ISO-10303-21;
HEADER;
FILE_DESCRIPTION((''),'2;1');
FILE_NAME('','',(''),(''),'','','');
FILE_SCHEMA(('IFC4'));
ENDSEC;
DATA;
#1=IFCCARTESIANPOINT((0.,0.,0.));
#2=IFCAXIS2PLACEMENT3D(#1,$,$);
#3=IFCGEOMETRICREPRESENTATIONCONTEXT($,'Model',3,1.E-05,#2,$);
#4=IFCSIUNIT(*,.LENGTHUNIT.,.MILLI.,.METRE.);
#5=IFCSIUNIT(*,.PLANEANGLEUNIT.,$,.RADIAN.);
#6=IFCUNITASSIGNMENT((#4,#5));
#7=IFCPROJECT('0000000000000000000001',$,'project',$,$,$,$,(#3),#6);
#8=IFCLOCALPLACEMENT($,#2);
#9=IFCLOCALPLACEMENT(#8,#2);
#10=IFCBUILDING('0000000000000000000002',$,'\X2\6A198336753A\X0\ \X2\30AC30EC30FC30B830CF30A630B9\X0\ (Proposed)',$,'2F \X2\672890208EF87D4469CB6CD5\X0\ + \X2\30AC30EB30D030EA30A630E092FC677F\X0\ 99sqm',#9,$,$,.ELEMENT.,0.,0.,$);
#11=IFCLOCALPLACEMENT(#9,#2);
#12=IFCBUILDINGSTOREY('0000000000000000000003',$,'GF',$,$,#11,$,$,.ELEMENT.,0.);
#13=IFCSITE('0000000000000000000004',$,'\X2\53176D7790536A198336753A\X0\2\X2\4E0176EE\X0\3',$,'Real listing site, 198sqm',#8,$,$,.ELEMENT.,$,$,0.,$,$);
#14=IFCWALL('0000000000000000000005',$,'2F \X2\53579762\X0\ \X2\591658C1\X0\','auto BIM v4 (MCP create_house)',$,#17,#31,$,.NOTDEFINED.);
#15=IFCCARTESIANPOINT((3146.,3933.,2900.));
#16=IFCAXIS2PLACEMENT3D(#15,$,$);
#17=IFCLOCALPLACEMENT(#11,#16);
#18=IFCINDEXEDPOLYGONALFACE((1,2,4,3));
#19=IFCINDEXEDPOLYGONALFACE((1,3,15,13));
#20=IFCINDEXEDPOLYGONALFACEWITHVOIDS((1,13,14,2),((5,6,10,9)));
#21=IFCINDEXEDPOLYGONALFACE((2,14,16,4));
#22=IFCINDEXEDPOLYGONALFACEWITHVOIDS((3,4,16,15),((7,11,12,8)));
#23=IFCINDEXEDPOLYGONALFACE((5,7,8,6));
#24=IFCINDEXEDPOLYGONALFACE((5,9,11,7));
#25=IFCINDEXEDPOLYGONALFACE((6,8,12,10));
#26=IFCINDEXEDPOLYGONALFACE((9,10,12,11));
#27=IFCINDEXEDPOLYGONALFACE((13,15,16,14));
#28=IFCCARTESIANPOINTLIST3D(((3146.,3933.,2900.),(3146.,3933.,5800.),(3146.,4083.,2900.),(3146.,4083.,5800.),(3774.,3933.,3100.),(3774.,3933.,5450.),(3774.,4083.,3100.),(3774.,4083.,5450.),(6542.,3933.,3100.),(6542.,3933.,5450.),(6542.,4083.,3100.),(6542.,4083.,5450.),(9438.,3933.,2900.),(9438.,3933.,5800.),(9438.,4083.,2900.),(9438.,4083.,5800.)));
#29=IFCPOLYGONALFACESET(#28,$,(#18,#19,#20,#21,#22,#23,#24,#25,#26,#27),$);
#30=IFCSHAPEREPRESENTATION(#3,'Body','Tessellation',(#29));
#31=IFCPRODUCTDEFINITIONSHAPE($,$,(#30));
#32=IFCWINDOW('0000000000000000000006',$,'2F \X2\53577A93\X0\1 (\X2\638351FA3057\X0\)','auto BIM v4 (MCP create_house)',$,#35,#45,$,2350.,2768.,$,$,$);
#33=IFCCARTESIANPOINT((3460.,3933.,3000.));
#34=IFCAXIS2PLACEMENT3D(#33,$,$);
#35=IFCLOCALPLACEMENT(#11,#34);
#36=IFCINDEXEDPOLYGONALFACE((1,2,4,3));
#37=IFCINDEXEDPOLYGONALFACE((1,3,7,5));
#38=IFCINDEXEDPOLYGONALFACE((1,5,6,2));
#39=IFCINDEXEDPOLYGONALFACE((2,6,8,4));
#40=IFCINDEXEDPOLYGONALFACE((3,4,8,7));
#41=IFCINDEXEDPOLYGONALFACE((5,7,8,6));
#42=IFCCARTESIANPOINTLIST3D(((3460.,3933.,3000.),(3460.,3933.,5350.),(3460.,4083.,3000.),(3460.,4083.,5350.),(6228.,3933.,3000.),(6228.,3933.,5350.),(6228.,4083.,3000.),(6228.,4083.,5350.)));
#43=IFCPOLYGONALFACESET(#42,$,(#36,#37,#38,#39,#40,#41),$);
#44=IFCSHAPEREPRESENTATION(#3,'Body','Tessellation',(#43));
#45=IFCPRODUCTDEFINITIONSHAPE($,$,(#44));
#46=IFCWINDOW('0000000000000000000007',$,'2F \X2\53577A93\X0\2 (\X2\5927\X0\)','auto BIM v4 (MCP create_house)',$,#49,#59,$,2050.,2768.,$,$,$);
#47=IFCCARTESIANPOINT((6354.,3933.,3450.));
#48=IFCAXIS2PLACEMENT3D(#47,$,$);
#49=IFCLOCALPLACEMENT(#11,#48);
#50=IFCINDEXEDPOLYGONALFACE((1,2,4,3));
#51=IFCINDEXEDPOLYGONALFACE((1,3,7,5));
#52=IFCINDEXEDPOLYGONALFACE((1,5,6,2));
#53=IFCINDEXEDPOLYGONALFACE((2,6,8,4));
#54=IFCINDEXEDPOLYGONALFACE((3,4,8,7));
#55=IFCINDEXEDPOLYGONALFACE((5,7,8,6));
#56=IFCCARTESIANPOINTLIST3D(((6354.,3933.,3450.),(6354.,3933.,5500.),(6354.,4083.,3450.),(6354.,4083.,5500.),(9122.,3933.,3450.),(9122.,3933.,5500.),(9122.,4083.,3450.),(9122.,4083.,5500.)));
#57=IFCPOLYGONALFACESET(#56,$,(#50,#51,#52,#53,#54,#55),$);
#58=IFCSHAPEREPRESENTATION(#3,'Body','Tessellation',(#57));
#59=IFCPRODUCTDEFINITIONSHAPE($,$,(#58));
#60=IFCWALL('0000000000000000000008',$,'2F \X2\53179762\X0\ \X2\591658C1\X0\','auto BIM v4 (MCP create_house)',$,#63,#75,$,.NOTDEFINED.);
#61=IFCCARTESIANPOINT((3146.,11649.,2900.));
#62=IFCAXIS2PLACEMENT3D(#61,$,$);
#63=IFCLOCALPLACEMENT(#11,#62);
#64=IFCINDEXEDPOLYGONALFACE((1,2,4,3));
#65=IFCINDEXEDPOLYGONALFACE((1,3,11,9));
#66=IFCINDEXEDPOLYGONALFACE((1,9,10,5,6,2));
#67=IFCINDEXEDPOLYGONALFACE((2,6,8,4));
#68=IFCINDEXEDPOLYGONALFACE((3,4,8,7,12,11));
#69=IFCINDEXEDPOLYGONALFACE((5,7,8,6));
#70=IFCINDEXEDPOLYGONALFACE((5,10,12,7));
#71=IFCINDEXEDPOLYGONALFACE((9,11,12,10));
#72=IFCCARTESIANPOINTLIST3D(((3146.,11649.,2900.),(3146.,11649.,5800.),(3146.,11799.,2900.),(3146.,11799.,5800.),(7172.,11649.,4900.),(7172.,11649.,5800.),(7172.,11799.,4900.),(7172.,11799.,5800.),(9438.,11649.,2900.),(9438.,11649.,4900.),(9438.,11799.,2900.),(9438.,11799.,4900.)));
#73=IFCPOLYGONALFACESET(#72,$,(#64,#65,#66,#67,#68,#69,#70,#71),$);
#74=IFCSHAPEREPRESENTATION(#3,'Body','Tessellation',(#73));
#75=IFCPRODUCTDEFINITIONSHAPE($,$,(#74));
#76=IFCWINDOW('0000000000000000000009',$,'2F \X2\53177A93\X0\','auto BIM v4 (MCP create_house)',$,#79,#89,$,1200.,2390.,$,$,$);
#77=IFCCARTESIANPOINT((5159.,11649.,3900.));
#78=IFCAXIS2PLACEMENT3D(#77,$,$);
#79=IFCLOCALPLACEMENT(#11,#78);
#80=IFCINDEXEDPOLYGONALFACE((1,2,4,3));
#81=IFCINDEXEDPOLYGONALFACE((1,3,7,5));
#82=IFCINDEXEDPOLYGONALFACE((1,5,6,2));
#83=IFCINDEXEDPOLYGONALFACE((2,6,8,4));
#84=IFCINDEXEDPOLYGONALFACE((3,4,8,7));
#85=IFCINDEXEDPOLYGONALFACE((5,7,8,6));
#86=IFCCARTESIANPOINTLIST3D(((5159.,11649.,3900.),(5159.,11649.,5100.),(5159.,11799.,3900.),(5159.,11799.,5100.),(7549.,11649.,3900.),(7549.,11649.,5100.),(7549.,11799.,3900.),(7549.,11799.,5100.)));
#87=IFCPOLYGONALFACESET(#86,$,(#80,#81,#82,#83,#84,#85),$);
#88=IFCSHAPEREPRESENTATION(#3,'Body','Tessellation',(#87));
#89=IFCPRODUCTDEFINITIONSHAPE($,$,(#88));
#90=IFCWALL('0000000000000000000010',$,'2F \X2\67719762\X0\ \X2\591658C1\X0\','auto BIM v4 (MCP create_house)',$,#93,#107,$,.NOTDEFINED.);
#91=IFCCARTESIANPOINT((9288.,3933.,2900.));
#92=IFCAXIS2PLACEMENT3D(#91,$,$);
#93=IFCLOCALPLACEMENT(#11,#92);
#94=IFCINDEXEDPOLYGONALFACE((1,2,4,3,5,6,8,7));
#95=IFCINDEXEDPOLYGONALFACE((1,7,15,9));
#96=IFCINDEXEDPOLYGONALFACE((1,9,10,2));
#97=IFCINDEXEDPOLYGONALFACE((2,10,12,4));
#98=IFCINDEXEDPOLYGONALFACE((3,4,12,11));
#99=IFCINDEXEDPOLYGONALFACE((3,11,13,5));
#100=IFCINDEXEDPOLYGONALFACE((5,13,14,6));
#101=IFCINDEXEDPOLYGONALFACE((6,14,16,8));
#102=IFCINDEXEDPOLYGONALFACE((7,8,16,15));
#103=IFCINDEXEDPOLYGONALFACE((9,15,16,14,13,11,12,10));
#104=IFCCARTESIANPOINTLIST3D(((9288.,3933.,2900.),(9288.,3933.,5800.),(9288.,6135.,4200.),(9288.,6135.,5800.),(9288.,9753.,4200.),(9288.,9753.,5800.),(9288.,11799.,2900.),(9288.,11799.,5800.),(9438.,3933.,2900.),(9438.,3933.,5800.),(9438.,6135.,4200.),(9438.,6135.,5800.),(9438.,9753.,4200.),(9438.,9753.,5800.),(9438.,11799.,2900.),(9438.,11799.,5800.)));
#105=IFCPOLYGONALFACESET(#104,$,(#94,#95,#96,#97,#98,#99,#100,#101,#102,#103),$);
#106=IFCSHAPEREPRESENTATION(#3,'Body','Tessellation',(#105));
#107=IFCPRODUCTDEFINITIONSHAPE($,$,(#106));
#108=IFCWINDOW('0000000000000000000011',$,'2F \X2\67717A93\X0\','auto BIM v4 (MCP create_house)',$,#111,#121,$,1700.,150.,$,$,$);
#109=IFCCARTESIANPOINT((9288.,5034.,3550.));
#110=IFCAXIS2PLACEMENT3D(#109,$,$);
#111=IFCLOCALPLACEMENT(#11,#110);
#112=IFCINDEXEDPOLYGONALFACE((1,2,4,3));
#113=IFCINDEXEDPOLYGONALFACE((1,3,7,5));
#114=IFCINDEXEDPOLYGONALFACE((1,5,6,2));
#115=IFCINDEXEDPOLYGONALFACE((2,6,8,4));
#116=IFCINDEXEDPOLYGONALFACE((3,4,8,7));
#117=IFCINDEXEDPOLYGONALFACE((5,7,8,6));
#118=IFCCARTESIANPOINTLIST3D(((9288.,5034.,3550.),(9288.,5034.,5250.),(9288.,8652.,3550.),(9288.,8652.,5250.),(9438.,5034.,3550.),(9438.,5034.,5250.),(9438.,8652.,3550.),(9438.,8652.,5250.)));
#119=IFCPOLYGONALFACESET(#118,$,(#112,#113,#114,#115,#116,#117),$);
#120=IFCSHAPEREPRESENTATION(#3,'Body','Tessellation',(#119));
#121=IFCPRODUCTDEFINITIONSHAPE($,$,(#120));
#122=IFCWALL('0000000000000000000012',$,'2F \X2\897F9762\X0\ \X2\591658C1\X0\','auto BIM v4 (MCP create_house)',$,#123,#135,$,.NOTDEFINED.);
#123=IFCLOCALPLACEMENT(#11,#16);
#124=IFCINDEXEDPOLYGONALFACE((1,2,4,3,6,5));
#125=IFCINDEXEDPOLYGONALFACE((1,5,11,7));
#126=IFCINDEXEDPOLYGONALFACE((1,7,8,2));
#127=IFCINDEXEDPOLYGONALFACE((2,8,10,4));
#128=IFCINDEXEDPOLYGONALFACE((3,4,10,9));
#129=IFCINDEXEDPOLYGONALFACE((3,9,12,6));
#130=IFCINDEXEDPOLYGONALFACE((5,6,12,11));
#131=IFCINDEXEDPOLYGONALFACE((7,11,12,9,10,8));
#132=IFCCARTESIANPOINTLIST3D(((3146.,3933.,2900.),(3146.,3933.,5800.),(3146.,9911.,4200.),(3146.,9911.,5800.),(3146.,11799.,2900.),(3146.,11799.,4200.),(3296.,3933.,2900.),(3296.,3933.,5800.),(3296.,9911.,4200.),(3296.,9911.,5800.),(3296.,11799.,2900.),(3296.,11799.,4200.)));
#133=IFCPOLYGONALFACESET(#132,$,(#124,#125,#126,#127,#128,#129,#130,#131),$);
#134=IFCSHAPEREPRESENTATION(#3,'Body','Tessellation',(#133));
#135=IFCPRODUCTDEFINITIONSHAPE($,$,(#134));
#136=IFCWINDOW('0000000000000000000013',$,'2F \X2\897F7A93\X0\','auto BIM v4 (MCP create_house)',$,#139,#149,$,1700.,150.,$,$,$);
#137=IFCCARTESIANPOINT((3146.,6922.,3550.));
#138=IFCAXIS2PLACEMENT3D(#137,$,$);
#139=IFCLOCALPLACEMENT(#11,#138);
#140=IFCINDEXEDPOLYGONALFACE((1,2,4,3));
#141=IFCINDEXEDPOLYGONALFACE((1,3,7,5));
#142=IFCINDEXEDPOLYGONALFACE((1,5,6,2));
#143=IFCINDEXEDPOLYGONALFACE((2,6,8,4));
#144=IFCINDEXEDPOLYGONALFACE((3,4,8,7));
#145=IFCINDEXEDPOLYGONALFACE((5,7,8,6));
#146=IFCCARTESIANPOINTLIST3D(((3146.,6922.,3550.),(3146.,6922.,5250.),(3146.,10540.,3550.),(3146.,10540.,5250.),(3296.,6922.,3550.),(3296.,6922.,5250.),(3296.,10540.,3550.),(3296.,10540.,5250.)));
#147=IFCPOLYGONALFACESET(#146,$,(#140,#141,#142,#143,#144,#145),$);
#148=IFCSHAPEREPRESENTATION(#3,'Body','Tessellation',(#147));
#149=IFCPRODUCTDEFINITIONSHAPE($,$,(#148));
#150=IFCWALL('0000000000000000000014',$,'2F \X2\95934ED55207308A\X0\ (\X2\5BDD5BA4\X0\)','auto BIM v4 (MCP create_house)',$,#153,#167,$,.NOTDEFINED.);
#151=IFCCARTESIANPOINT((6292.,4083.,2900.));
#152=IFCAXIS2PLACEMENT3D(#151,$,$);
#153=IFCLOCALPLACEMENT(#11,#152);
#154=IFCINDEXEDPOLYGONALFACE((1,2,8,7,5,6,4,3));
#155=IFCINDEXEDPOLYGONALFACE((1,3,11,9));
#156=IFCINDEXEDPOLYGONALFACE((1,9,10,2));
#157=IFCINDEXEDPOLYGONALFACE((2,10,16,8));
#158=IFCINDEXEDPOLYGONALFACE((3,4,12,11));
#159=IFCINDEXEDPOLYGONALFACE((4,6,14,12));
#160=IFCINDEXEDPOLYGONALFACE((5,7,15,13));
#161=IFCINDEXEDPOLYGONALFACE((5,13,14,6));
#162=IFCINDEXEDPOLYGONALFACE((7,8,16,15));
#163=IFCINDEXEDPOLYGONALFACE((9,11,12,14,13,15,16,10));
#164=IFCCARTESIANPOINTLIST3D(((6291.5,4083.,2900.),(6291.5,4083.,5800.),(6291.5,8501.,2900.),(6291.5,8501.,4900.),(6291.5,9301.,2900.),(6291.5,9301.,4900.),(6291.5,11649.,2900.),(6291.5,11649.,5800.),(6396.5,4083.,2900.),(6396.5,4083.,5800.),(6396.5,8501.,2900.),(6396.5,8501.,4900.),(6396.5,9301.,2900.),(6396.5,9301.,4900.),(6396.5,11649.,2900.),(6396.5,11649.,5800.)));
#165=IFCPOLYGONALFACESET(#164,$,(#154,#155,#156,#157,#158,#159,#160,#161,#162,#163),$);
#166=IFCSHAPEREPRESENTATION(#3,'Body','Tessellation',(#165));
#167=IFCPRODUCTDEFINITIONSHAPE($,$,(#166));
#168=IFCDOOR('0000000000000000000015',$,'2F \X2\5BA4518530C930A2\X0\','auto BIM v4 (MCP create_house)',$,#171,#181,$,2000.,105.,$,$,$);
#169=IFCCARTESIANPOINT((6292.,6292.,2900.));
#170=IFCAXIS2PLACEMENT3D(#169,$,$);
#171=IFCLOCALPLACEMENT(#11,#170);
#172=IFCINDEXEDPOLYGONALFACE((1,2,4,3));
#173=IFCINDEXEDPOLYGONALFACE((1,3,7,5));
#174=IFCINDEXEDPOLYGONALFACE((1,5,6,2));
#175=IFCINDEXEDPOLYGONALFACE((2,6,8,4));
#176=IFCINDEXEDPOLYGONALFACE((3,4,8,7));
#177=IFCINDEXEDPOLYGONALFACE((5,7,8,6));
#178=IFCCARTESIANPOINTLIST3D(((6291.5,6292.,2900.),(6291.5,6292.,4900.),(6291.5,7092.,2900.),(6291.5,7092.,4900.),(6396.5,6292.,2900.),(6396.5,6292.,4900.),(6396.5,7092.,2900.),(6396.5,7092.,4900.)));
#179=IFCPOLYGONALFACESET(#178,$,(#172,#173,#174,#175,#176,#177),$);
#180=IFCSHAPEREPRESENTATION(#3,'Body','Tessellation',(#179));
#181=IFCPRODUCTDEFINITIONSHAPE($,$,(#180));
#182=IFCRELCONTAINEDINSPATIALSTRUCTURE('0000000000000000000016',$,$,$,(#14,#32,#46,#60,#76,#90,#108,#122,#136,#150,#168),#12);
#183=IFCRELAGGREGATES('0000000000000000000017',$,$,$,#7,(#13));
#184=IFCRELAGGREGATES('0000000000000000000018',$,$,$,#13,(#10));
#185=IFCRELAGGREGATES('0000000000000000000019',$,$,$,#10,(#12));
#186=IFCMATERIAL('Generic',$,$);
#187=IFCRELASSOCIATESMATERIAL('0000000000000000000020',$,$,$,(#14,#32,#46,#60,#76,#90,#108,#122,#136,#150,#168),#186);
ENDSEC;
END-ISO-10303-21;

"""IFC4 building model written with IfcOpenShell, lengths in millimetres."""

from ifc_helpers import new_model, si_unit, frame, frame_2d, origin, place, context, project, spatial, rectangle, extrude, material, element, fill, save


model = new_model("IFC4")

# Units and contexts
model_context = context("Model", 3, precision=1e-05, world=origin())
ifc_project = project(units=[si_unit("LENGTHUNIT", "METRE", prefix="MILLI"), si_unit("PLANEANGLEUNIT", "RADIAN")], contexts=[model_context])

# Site, building, storey
site_placement = place(None, origin())
site = spatial("IfcSite", under=ifc_project, at=site_placement, Name="北海道標茶町2丁目3", ObjectType="Real listing site, 198sqm", CompositionType="ELEMENT", RefElevation=0.0)
building_placement = place(site_placement, origin())
building = spatial("IfcBuilding", under=site, at=building_placement, Name="標茶町 ガレージハウス (Proposed)", ObjectType="2F 木造軸組構法 + ガルバリウム鋼板 99sqm", CompositionType="ELEMENT", ElevationOfRefHeight=0.0, ElevationOfTerrain=0.0)
storey_placement = place(building_placement, origin())
storey = spatial("IfcBuildingStorey", under=building, at=storey_placement, Name="GF", CompositionType="ELEMENT", Elevation=0.0)

# Shared definitions
ifc_material = material(Name="Generic")

# Wall, openings, windows
wall_1_placement = place(storey_placement, frame((3146.0, 3933.0, 2900.0)))
wall_1 = element("IfcWall", 1, at=wall_1_placement, inside=storey, material=ifc_material, Name="2F 南面 外壁", Description="auto BIM v4 (MCP create_house)", PredefinedType="NOTDEFINED", context=model_context, shape_type="SweptSolid", body=[
    extrude(rectangle(XDim=6292.0, YDim=150.0, at=frame_2d((3146.0, 75.0))), frame((3146.0, 3933.0, 2900.0)), (0.0, 0.0, 1.0), 2900.0),
])
opening_1_placement = place(storey_placement, frame((3460.0, 3933.0, 3000.0)))
opening_1 = element("IfcOpeningElement", 2, at=opening_1_placement, cuts=wall_1, PredefinedType="NOTDEFINED", context=model_context, shape_type="SweptSolid", body=[
    extrude(rectangle(XDim=2768.0, YDim=150.0, at=frame_2d((1384.0, 75.0))), frame((3460.0, 3933.0, 3000.0)), (0.0, 0.0, 1.0), 2350.0),
])
opening_2_placement = place(storey_placement, frame((6354.0, 3933.0, 3450.0)))
opening_2 = element("IfcOpeningElement", 3, at=opening_2_placement, cuts=wall_1, PredefinedType="NOTDEFINED", context=model_context, shape_type="SweptSolid", body=[
    extrude(rectangle(XDim=2768.0, YDim=150.0, at=frame_2d((1384.0, 75.0))), frame((6354.0, 3933.0, 3450.0)), (0.0, 0.0, 1.0), 2050.0),
])
window_1_placement = place(storey_placement, frame((3460.0, 3933.0, 3000.0)))
window_1 = element("IfcWindow", 4, at=window_1_placement, inside=storey, material=ifc_material, Name="2F 南窓1 (掃出し)", Description="auto BIM v4 (MCP create_house)", OverallHeight=2350.0, OverallWidth=2768.0, context=model_context, shape_type="SweptSolid", body=[
    extrude(rectangle(XDim=2768.0, YDim=150.0, at=frame_2d((1384.0, 75.0))), frame((3460.0, 3933.0, 3000.0)), (0.0, 0.0, 1.0), 2350.0),
])
fill(opening_1, window_1)
window_2_placement = place(storey_placement, frame((6354.0, 3933.0, 3450.0)))
window_2 = element("IfcWindow", 5, at=window_2_placement, inside=storey, material=ifc_material, Name="2F 南窓2 (大)", Description="auto BIM v4 (MCP create_house)", OverallHeight=2050.0, OverallWidth=2768.0, context=model_context, shape_type="SweptSolid", body=[
    extrude(rectangle(XDim=2768.0, YDim=150.0, at=frame_2d((1384.0, 75.0))), frame((6354.0, 3933.0, 3450.0)), (0.0, 0.0, 1.0), 2050.0),
])
fill(opening_2, window_2)

# Walls, openings, windows
wall_2_placement = place(storey_placement, frame((3146.0, 11649.0, 2900.0)))
wall_2 = element("IfcWall", 6, at=wall_2_placement, inside=storey, material=ifc_material, Name="2F 北面 外壁", Description="auto BIM v4 (MCP create_house)", PredefinedType="NOTDEFINED", context=model_context, shape_type="SweptSolid", body=[
    extrude(rectangle(XDim=6292.0, YDim=150.0, at=frame_2d((3146.0, 75.0))), frame((3146.0, 11649.0, 2900.0)), (0.0, 0.0, 1.0), 2900.0),
])
opening_3_placement = place(storey_placement, frame((5159.0, 11649.0, 3900.0)))
opening_3 = element("IfcOpeningElement", 7, at=opening_3_placement, cuts=wall_2, PredefinedType="NOTDEFINED", context=model_context, shape_type="SweptSolid", body=[
    extrude(rectangle(XDim=2390.0, YDim=150.0, at=frame_2d((1195.0, 75.0))), frame((5159.0, 11649.0, 3900.0)), (0.0, 0.0, 1.0), 1200.0),
])
window_3_placement = place(storey_placement, frame((5159.0, 11649.0, 3900.0)))
window_3 = element("IfcWindow", 8, at=window_3_placement, inside=storey, material=ifc_material, Name="2F 北窓", Description="auto BIM v4 (MCP create_house)", OverallHeight=1200.0, OverallWidth=2390.0, context=model_context, shape_type="SweptSolid", body=[
    extrude(rectangle(XDim=2390.0, YDim=150.0, at=frame_2d((1195.0, 75.0))), frame((5159.0, 11649.0, 3900.0)), (0.0, 0.0, 1.0), 1200.0),
])
fill(opening_3, window_3)
wall_3_placement = place(storey_placement, frame((9288.0, 3933.0, 2900.0)))
wall_3 = element("IfcWall", 9, at=wall_3_placement, inside=storey, material=ifc_material, Name="2F 東面 外壁", Description="auto BIM v4 (MCP create_house)", PredefinedType="NOTDEFINED", context=model_context, shape_type="SweptSolid", body=[
    extrude(rectangle(XDim=150.0, YDim=7866.0, at=frame_2d((75.0, 3933.0))), frame((9288.0, 3933.0, 2900.0)), (0.0, 0.0, 1.0), 2900.0),
])
opening_4_placement = place(storey_placement, frame((9288.0, 5034.0, 3550.0)))
opening_4 = element("IfcOpeningElement", 10, at=opening_4_placement, cuts=wall_3, PredefinedType="NOTDEFINED", context=model_context, shape_type="SweptSolid", body=[
    extrude(rectangle(XDim=150.0, YDim=3618.0, at=frame_2d((75.0, 1809.0))), frame((9288.0, 5034.0, 3550.0)), (0.0, 0.0, 1.0), 1700.0),
])
window_4_placement = place(storey_placement, frame((9288.0, 5034.0, 3550.0)))
window_4 = element("IfcWindow", 11, at=window_4_placement, inside=storey, material=ifc_material, Name="2F 東窓", Description="auto BIM v4 (MCP create_house)", OverallHeight=1700.0, OverallWidth=150.0, context=model_context, shape_type="SweptSolid", body=[
    extrude(rectangle(XDim=150.0, YDim=3618.0, at=frame_2d((75.0, 1809.0))), frame((9288.0, 5034.0, 3550.0)), (0.0, 0.0, 1.0), 1700.0),
])
fill(opening_4, window_4)
wall_4_placement = place(storey_placement, frame((3146.0, 3933.0, 2900.0)))
wall_4 = element("IfcWall", 12, at=wall_4_placement, inside=storey, material=ifc_material, Name="2F 西面 外壁", Description="auto BIM v4 (MCP create_house)", PredefinedType="NOTDEFINED", context=model_context, shape_type="SweptSolid", body=[
    extrude(rectangle(XDim=150.0, YDim=7866.0, at=frame_2d((75.0, 3933.0))), frame((3146.0, 3933.0, 2900.0)), (0.0, 0.0, 1.0), 2900.0),
])
opening_5_placement = place(storey_placement, frame((3146.0, 6922.0, 3550.0)))
opening_5 = element("IfcOpeningElement", 13, at=opening_5_placement, cuts=wall_4, PredefinedType="NOTDEFINED", context=model_context, shape_type="SweptSolid", body=[
    extrude(rectangle(XDim=150.0, YDim=3618.0, at=frame_2d((75.0, 1809.0))), frame((3146.0, 6922.0, 3550.0)), (0.0, 0.0, 1.0), 1700.0),
])
window_5_placement = place(storey_placement, frame((3146.0, 6922.0, 3550.0)))
window_5 = element("IfcWindow", 14, at=window_5_placement, inside=storey, material=ifc_material, Name="2F 西窓", Description="auto BIM v4 (MCP create_house)", OverallHeight=1700.0, OverallWidth=150.0, context=model_context, shape_type="SweptSolid", body=[
    extrude(rectangle(XDim=150.0, YDim=3618.0, at=frame_2d((75.0, 1809.0))), frame((3146.0, 6922.0, 3550.0)), (0.0, 0.0, 1.0), 1700.0),
])
fill(opening_5, window_5)

# Wall, opening, door
wall_5_placement = place(storey_placement, frame((6292.0, 4083.0, 2900.0)))
wall_5 = element("IfcWall", 15, at=wall_5_placement, inside=storey, material=ifc_material, Name="2F 間仕切り (寝室)", Description="auto BIM v4 (MCP create_house)", PredefinedType="NOTDEFINED", context=model_context, shape_type="SweptSolid", body=[
    extrude(rectangle(XDim=105.0, YDim=7566.0, at=frame_2d((52.0, 3783.0))), frame((6292.0, 4083.0, 2900.0)), (0.0, 0.0, 1.0), 2900.0),
])
opening_6_placement = place(storey_placement, frame((6292.0, 6292.0, 2900.0)))
opening_6 = element("IfcOpeningElement", 16, at=opening_6_placement, cuts=wall_5, PredefinedType="NOTDEFINED", context=model_context, shape_type="SweptSolid", body=[
    extrude(rectangle(XDim=105.0, YDim=800.0, at=frame_2d((52.0, 400.0))), frame((6292.0, 6292.0, 2900.0)), (0.0, 0.0, 1.0), 2000.0),
])
door_1_placement = place(storey_placement, frame((6292.0, 6292.0, 2900.0)))
door_1 = element("IfcDoor", 17, at=door_1_placement, inside=storey, material=ifc_material, Name="2F 室内ドア", Description="auto BIM v4 (MCP create_house)", OverallHeight=2000.0, OverallWidth=105.0, context=model_context, shape_type="SweptSolid", body=[
    extrude(rectangle(XDim=105.0, YDim=800.0, at=frame_2d((52.0, 400.0))), frame((6292.0, 6292.0, 2900.0)), (0.0, 0.0, 1.0), 2000.0),
])
fill(opening_6, door_1)

save(model, "model.ifc")
